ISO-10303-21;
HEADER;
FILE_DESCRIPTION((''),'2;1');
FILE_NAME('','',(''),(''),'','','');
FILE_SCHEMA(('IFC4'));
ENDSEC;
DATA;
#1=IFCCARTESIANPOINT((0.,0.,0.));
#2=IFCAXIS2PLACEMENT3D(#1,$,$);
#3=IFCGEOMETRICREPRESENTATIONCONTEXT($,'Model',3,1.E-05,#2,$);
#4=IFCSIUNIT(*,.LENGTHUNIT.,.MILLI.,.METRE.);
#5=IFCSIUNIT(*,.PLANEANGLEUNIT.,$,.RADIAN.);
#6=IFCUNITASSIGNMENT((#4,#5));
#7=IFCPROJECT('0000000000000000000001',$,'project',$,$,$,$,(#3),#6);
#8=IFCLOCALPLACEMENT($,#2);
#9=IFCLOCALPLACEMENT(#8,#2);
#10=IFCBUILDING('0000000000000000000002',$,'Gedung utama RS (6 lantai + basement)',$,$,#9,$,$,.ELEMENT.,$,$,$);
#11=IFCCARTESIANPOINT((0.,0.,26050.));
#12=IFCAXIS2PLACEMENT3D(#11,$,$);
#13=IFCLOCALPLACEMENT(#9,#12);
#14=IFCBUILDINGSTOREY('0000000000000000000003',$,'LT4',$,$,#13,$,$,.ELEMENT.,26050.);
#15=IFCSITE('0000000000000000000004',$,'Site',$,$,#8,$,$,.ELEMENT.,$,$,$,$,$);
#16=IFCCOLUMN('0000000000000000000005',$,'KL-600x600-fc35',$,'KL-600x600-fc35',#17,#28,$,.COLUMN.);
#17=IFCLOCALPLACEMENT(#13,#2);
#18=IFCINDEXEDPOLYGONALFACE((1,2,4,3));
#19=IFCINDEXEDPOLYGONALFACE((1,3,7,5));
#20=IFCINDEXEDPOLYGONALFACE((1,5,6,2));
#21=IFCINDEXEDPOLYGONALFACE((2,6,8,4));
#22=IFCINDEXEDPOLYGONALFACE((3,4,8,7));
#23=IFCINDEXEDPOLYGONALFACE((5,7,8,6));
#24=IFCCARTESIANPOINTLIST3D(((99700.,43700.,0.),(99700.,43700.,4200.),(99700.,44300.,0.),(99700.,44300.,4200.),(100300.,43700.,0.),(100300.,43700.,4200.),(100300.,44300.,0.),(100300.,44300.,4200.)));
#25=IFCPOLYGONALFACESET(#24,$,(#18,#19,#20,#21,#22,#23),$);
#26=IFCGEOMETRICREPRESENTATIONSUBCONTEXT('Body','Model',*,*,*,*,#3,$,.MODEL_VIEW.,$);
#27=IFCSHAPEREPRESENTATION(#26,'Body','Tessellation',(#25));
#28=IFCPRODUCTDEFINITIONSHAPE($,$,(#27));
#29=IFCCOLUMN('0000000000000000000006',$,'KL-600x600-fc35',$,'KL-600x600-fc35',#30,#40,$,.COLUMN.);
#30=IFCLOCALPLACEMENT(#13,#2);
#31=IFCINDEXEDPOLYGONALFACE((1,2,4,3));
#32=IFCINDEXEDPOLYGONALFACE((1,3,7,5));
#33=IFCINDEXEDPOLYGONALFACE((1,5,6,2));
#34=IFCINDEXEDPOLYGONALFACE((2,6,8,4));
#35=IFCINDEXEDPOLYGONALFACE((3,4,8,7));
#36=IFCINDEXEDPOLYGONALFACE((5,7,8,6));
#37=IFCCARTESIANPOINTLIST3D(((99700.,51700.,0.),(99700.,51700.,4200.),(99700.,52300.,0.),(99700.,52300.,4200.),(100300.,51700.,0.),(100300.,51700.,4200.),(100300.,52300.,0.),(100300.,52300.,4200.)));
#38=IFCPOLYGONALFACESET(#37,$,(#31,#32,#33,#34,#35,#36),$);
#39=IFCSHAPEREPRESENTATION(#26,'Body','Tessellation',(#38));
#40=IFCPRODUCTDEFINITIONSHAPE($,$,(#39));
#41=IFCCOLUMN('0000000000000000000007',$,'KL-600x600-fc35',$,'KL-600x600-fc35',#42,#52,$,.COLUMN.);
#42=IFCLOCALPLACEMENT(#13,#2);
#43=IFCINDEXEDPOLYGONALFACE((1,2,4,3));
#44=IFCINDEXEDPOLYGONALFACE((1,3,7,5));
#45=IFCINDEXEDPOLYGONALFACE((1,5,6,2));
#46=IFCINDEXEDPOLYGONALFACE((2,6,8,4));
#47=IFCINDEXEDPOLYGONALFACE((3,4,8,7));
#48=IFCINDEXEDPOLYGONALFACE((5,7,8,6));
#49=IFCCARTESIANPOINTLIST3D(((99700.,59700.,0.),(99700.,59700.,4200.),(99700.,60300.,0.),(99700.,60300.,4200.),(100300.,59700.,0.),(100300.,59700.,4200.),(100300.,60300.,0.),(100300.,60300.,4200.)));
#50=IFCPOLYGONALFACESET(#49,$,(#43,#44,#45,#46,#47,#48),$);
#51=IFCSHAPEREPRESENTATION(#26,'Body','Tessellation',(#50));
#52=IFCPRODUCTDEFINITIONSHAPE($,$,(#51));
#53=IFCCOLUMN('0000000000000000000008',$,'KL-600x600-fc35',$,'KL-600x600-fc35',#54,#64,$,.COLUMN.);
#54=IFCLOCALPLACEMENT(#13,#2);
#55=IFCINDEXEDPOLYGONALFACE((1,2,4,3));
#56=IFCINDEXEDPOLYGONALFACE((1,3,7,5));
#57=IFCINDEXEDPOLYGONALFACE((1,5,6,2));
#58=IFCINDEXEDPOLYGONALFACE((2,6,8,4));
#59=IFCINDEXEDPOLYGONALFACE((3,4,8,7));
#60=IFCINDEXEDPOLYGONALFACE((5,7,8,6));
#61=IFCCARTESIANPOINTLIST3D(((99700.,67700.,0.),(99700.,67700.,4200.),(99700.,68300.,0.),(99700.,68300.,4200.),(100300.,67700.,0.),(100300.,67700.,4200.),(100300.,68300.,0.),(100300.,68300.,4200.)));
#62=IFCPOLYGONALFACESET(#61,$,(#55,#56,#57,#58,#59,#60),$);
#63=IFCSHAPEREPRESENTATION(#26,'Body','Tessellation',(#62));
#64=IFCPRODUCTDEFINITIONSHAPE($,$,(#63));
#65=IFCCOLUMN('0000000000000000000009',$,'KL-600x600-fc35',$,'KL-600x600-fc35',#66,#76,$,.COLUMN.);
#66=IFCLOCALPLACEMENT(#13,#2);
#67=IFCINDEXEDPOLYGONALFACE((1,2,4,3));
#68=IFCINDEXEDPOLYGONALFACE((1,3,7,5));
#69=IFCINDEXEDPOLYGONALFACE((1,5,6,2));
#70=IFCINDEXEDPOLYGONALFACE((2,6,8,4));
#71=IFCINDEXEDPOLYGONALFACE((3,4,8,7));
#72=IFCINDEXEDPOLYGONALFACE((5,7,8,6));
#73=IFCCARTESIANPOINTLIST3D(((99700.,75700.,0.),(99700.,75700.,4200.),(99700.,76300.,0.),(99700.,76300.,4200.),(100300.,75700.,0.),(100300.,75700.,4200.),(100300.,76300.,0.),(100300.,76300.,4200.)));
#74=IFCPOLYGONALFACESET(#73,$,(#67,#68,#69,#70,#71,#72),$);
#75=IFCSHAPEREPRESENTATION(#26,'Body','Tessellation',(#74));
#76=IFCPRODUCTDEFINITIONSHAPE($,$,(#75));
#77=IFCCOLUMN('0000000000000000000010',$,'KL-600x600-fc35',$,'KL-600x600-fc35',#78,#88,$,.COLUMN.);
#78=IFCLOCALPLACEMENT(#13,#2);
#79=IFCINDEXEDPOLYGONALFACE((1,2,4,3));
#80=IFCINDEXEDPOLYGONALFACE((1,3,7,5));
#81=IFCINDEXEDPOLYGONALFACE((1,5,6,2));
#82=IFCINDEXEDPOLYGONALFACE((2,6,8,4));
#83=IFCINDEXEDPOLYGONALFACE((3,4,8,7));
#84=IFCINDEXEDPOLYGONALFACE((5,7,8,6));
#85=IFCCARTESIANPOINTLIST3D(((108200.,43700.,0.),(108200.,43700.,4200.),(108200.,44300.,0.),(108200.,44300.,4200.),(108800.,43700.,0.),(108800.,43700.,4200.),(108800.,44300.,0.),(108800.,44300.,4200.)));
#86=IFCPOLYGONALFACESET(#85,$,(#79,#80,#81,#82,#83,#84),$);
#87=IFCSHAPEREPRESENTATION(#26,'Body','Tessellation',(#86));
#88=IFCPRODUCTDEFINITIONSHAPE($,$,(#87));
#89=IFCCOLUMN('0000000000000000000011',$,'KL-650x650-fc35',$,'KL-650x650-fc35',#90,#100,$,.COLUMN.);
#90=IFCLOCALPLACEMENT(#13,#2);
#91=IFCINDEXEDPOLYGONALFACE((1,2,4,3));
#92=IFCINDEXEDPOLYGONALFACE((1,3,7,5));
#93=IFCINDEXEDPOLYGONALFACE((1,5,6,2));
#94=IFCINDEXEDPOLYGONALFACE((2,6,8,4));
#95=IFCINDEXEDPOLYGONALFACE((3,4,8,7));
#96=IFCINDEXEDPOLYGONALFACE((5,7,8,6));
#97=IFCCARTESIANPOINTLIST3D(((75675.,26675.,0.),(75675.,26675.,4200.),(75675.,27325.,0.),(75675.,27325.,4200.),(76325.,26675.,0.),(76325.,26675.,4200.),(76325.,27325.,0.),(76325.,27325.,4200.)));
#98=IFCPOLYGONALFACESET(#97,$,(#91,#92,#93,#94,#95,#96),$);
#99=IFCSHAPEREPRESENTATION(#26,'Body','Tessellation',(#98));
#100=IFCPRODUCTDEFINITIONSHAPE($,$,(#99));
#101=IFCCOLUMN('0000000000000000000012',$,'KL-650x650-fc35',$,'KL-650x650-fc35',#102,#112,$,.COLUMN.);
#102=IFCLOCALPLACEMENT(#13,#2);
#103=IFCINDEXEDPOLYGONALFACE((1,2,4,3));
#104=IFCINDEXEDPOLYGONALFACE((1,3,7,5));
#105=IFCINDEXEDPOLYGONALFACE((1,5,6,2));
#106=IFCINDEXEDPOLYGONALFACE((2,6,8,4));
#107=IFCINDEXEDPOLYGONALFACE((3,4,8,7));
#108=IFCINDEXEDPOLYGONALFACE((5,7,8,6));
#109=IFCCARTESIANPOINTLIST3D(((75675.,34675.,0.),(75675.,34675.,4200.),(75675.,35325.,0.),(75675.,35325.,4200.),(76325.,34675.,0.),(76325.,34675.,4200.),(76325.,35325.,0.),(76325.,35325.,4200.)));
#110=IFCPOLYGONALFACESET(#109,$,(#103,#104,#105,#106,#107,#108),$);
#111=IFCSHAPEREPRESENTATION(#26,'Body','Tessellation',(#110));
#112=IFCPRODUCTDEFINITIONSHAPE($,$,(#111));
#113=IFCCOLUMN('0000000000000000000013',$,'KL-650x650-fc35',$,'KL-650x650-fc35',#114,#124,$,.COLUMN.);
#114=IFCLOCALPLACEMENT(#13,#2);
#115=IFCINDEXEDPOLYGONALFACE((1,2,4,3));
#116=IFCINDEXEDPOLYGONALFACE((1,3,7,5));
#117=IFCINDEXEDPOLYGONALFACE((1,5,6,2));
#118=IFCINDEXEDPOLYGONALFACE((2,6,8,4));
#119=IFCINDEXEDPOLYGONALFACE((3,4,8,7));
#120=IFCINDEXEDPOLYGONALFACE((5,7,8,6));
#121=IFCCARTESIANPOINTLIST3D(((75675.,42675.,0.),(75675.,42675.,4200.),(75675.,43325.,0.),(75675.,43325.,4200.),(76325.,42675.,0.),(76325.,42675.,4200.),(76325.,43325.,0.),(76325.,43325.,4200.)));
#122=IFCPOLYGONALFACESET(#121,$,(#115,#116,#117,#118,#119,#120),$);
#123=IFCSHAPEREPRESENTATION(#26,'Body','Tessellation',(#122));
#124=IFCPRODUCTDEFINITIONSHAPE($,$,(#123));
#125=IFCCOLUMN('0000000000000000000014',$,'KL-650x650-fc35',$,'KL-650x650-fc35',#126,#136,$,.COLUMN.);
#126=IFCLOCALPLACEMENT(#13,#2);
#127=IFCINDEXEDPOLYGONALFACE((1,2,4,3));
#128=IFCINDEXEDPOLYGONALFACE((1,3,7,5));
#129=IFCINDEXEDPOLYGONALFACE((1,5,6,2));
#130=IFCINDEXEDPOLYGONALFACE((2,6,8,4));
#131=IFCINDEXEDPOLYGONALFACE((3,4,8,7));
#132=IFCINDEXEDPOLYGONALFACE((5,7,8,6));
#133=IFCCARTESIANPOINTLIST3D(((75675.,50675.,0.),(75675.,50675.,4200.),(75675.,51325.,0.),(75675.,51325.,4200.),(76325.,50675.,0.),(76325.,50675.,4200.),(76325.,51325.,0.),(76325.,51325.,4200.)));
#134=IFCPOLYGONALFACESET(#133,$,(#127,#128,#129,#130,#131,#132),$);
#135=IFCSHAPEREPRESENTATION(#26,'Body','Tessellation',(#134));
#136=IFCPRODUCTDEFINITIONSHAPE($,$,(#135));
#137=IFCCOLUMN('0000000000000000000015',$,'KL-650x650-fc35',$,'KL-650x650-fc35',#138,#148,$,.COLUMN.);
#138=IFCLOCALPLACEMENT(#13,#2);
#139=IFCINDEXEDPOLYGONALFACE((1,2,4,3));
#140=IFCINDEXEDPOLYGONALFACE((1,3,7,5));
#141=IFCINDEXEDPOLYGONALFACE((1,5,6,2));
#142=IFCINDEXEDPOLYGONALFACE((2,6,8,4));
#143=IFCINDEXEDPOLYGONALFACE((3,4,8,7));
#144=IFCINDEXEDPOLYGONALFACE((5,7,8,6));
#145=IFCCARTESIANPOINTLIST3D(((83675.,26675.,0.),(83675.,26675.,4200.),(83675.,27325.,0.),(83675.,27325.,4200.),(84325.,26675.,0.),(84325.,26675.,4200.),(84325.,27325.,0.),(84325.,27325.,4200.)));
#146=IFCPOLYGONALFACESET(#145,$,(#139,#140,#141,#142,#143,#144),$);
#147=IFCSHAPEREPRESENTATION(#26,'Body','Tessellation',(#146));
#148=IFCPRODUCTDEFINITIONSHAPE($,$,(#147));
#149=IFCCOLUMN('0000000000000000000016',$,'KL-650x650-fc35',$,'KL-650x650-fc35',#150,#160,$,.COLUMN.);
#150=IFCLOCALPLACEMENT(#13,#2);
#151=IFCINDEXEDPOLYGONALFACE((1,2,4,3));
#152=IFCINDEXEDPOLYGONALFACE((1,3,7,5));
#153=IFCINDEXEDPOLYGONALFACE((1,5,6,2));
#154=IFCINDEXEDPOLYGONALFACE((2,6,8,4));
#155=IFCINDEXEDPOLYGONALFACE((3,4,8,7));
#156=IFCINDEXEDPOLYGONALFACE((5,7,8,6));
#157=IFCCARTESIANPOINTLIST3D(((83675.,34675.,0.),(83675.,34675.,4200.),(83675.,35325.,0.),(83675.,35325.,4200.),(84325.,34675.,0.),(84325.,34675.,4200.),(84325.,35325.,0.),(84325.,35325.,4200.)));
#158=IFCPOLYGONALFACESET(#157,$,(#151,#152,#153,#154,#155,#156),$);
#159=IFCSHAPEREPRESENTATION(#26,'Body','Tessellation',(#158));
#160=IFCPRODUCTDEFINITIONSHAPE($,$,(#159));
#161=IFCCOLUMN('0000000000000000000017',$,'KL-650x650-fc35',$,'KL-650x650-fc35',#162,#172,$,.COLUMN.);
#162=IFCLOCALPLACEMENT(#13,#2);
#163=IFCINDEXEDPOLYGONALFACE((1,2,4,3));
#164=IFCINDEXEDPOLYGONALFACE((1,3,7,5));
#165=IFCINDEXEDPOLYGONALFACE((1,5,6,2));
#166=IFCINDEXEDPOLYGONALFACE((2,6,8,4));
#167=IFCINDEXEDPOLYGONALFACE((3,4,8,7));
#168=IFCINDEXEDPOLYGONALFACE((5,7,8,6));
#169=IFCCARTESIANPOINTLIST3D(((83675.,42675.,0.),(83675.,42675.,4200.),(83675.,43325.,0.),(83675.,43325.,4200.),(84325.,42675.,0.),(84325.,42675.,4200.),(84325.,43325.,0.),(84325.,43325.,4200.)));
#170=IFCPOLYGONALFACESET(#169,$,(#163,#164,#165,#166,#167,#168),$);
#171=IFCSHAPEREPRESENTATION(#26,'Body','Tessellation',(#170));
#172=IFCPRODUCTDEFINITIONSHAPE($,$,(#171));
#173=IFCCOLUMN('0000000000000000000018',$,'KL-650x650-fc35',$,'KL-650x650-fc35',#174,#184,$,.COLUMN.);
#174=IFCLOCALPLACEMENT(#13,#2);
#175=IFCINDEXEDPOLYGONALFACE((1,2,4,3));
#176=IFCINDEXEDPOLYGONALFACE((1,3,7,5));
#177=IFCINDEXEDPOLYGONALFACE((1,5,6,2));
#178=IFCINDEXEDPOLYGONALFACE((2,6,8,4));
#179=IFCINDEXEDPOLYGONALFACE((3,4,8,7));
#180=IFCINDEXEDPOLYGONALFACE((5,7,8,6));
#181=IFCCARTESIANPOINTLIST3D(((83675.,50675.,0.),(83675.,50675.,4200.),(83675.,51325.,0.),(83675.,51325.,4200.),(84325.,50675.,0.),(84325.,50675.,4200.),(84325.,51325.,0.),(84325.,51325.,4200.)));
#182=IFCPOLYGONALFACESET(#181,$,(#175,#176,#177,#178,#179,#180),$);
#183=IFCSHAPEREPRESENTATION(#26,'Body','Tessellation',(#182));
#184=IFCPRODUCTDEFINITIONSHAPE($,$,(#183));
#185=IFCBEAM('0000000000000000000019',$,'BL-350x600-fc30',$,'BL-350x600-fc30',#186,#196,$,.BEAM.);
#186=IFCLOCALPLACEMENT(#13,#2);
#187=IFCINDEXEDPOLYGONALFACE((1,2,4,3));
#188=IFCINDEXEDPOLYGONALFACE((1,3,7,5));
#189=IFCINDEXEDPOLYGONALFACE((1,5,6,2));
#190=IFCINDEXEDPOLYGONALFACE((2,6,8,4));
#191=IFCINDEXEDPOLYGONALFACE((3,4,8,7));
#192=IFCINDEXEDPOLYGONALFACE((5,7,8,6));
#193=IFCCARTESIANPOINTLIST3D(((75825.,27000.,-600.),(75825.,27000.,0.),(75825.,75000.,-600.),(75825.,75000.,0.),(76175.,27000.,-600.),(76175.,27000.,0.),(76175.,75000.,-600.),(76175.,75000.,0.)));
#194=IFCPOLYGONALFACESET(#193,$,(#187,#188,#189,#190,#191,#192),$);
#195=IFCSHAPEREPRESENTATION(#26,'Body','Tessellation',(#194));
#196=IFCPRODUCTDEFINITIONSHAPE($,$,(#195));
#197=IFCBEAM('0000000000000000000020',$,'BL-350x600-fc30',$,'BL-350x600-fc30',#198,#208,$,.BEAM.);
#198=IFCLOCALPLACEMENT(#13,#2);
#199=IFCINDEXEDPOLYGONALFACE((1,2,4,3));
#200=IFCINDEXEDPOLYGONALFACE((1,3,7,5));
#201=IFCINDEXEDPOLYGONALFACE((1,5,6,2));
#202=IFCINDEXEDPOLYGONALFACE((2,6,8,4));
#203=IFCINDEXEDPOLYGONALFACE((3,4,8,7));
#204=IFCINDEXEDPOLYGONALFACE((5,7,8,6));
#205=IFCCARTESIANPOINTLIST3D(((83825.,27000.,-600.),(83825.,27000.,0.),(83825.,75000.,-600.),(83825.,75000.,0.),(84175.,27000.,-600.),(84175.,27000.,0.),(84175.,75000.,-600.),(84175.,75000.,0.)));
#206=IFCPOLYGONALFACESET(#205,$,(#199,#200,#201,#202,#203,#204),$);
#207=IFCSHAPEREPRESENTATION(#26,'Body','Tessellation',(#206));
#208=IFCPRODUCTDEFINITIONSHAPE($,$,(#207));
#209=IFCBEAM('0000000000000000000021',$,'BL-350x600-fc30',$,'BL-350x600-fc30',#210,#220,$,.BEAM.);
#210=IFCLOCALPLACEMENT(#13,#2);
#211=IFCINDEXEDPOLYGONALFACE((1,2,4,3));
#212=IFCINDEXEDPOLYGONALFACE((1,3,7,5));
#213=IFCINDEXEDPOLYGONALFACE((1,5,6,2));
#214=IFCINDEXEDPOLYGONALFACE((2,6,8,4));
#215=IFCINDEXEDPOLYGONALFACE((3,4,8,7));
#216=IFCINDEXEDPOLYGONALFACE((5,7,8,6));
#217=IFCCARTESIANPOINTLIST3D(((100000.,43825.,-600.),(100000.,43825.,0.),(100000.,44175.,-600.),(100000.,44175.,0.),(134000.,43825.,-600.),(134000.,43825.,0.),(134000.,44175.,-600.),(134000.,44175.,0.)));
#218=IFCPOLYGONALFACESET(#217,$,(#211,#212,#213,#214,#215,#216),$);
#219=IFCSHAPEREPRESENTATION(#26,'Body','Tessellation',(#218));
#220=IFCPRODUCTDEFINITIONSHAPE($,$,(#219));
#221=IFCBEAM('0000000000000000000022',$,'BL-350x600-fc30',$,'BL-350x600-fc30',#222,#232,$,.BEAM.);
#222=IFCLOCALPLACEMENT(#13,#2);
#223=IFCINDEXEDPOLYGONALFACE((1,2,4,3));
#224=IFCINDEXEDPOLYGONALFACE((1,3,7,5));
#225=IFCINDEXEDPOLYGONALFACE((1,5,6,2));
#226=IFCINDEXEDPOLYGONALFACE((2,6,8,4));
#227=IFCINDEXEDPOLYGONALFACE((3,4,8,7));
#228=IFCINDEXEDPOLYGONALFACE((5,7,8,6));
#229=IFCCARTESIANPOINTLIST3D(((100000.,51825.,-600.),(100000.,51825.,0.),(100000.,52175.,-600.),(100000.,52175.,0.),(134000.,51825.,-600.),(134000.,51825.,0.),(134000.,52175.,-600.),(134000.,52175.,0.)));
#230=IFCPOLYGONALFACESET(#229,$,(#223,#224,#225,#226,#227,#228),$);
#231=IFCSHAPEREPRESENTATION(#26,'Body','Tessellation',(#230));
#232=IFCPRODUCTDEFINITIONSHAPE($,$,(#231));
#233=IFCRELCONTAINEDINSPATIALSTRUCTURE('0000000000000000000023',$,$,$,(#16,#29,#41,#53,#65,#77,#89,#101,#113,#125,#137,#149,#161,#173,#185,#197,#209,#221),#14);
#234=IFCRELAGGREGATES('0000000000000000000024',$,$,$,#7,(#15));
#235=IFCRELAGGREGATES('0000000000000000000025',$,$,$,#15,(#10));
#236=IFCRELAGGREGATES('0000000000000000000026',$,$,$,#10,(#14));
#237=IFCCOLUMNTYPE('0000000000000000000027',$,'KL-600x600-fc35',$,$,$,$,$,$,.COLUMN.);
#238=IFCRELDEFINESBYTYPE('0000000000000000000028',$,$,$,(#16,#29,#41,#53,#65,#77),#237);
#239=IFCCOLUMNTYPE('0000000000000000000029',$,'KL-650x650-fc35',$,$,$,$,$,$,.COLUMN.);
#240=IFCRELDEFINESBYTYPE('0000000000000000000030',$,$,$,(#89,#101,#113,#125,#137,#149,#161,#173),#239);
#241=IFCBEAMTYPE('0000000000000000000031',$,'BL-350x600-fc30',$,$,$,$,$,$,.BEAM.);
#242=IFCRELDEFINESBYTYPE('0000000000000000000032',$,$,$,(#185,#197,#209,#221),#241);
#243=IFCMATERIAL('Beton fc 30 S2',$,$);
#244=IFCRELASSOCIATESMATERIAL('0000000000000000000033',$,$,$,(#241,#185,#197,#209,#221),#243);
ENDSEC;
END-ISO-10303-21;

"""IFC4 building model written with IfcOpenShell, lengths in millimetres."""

from ifc_helpers import new_model, si_unit, frame, origin, origin_2d, place, context, subcontext, project, spatial, rectangle, extrude, material, material_profile, profile_set, profile_usage, type_object, element, save


model = new_model("IFC4")

# Units and contexts
model_context = context("Model", 3, precision=1e-05, world=origin())
body_context = subcontext(model_context, "Body", "Model", "MODEL_VIEW")
ifc_project = project(units=[si_unit("LENGTHUNIT", "METRE", prefix="MILLI"), si_unit("PLANEANGLEUNIT", "RADIAN")], contexts=[model_context])

# Site, building, storey
site_placement = place(None, origin())
site = spatial("IfcSite", under=ifc_project, at=site_placement, Name="Site", CompositionType="ELEMENT")
building_placement = place(site_placement, origin())
building = spatial("IfcBuilding", under=site, at=building_placement, Name="Gedung utama RS (6 lantai + basement)", CompositionType="ELEMENT")
storey_placement = place(building_placement, frame((0.0, 0.0, 26050.0)))
storey = spatial("IfcBuildingStorey", under=building, at=storey_placement, Name="LT4", CompositionType="ELEMENT", Elevation=26050.0)

# Columns
ifc_material_profile_1 = material_profile(None, rectangle(XDim=600.0, YDim=600.0, at=origin_2d()), Name="KL-600x600-fc35")
ifc_profile_set_1 = profile_set([ifc_material_profile_1], Name="KL-600x600-fc35")
ifc_profile_usage_1 = profile_usage(ifc_profile_set_1, cardinal=5)
column_type_1 = type_object("IfcColumnType", Name="KL-600x600-fc35", PredefinedType="COLUMN", material=ifc_profile_set_1)
for number, where, z_axis, x_axis, name in (
    (1, (100000.0, 44000.0, 0.0), (0.0, 0.0, 1.0), (1.0, 0.0, 0.0), "KL-600x600-fc35"),
    (2, (100000.0, 52000.0, 0.0), (0.0, 0.0, 1.0), (1.0, 0.0, 0.0), "KL-600x600-fc35"),
    (3, (100000.0, 60000.0, 0.0), (0.0, 0.0, 1.0), (1.0, 0.0, 0.0), "KL-600x600-fc35"),
    (4, (100000.0, 68000.0, 0.0), (0.0, 0.0, 1.0), (1.0, 0.0, 0.0), "KL-600x600-fc35"),
    (5, (100000.0, 76000.0, 0.0), (0.0, 0.0, 1.0), (1.0, 0.0, 0.0), "KL-600x600-fc35"),
    (6, (108500.0, 44000.0, 0.0), (0.0, 0.0, 1.0), (1.0, 0.0, 0.0), "KL-600x600-fc35"),
):
    element("IfcColumn", number, at=place(storey_placement, frame(where, z_axis=z_axis, x_axis=x_axis)), inside=storey, type_object=column_type_1, material=ifc_profile_usage_1, Name=name, ObjectType="KL-600x600-fc35", PredefinedType="COLUMN", context=body_context, shape_type="SweptSolid", body=[
        extrude(rectangle(XDim=600.0, YDim=600.0, at=origin_2d()), origin(), (0.0, 0.0, 1.0), 4200.0),
    ])
ifc_material_profile_2 = material_profile(None, rectangle(XDim=650.0, YDim=650.0, at=origin_2d()), Name="KL-650x650-fc35")
ifc_profile_set_2 = profile_set([ifc_material_profile_2], Name="KL-650x650-fc35")
ifc_profile_usage_2 = profile_usage(ifc_profile_set_2, cardinal=5)
column_type_2 = type_object("IfcColumnType", Name="KL-650x650-fc35", PredefinedType="COLUMN", material=ifc_profile_set_2)
for number, where, z_axis, x_axis, name in (
    (7, (76000.0, 27000.0, 0.0), (0.0, 0.0, 1.0), (1.0, 0.0, 0.0), "KL-650x650-fc35"),
    (8, (76000.0, 35000.0, 0.0), (0.0, 0.0, 1.0), (1.0, 0.0, 0.0), "KL-650x650-fc35"),
    (9, (76000.0, 43000.0, 0.0), (0.0, 0.0, 1.0), (1.0, 0.0, 0.0), "KL-650x650-fc35"),
    (10, (76000.0, 51000.0, 0.0), (0.0, 0.0, 1.0), (1.0, 0.0, 0.0), "KL-650x650-fc35"),
    (11, (84000.0, 27000.0, 0.0), (0.0, 0.0, 1.0), (1.0, 0.0, 0.0), "KL-650x650-fc35"),
    (12, (84000.0, 35000.0, 0.0), (0.0, 0.0, 1.0), (1.0, 0.0, 0.0), "KL-650x650-fc35"),
    (13, (84000.0, 43000.0, 0.0), (0.0, 0.0, 1.0), (1.0, 0.0, 0.0), "KL-650x650-fc35"),
    (14, (84000.0, 51000.0, 0.0), (0.0, 0.0, 1.0), (1.0, 0.0, 0.0), "KL-650x650-fc35"),
):
    element("IfcColumn", number, at=place(storey_placement, frame(where, z_axis=z_axis, x_axis=x_axis)), inside=storey, type_object=column_type_2, material=ifc_profile_usage_2, Name=name, ObjectType="KL-650x650-fc35", PredefinedType="COLUMN", context=body_context, shape_type="SweptSolid", body=[
        extrude(rectangle(XDim=650.0, YDim=650.0, at=origin_2d()), origin(), (0.0, 0.0, 1.0), 4200.0),
    ])

# Beams
ifc_material = material(Name="Beton fc 30 S2")
ifc_material_profile_3 = material_profile(ifc_material, rectangle(XDim=350.0, YDim=600.0, at=origin_2d()), Name="BL-350x600-fc30")
ifc_profile_set_3 = profile_set([ifc_material_profile_3], Name="BL-350x600-fc30")
ifc_profile_usage_3 = profile_usage(ifc_profile_set_3, cardinal=8)
beam_type = type_object("IfcBeamType", Name="BL-350x600-fc30", PredefinedType="BEAM", material=ifc_profile_set_3)
for number, where, name in (
    (15, (76000.0, 27000.0, -300.0), "BL-350x600-fc30"),
    (16, (84000.0, 27000.0, -300.0), "BL-350x600-fc30"),
):
    element("IfcBeam", number, at=place(storey_placement, frame(where)), inside=storey, type_object=beam_type, material=ifc_profile_usage_3, Name=name, ObjectType="BL-350x600-fc30", PredefinedType="BEAM", context=body_context, shape_type="SweptSolid", body=[
        extrude(rectangle(XDim=350.0, YDim=600.0, at=origin_2d()), frame((0.0, 0.0, 0.0), z_axis=(0.0, 1.0, 0.0), x_axis=(-1.0, 0.0, 0.0)), (0.0, 0.0, 1.0), 48000.0),
    ])
for number, where, name in (
    (17, (100000.0, 44000.0, -300.0), "BL-350x600-fc30"),
    (18, (100000.0, 52000.0, -300.0), "BL-350x600-fc30"),
):
    element("IfcBeam", number, at=place(storey_placement, frame(where)), inside=storey, type_object=beam_type, material=ifc_profile_usage_3, Name=name, ObjectType="BL-350x600-fc30", PredefinedType="BEAM", context=body_context, shape_type="SweptSolid", body=[
        extrude(rectangle(XDim=350.0, YDim=600.0, at=origin_2d()), frame((0.0, 0.0, 0.0), z_axis=(1.0, 0.0, 0.0), x_axis=(0.0, 1.0, 0.0)), (0.0, 0.0, 1.0), 34000.0),
    ])

save(model, "model.ifc")
